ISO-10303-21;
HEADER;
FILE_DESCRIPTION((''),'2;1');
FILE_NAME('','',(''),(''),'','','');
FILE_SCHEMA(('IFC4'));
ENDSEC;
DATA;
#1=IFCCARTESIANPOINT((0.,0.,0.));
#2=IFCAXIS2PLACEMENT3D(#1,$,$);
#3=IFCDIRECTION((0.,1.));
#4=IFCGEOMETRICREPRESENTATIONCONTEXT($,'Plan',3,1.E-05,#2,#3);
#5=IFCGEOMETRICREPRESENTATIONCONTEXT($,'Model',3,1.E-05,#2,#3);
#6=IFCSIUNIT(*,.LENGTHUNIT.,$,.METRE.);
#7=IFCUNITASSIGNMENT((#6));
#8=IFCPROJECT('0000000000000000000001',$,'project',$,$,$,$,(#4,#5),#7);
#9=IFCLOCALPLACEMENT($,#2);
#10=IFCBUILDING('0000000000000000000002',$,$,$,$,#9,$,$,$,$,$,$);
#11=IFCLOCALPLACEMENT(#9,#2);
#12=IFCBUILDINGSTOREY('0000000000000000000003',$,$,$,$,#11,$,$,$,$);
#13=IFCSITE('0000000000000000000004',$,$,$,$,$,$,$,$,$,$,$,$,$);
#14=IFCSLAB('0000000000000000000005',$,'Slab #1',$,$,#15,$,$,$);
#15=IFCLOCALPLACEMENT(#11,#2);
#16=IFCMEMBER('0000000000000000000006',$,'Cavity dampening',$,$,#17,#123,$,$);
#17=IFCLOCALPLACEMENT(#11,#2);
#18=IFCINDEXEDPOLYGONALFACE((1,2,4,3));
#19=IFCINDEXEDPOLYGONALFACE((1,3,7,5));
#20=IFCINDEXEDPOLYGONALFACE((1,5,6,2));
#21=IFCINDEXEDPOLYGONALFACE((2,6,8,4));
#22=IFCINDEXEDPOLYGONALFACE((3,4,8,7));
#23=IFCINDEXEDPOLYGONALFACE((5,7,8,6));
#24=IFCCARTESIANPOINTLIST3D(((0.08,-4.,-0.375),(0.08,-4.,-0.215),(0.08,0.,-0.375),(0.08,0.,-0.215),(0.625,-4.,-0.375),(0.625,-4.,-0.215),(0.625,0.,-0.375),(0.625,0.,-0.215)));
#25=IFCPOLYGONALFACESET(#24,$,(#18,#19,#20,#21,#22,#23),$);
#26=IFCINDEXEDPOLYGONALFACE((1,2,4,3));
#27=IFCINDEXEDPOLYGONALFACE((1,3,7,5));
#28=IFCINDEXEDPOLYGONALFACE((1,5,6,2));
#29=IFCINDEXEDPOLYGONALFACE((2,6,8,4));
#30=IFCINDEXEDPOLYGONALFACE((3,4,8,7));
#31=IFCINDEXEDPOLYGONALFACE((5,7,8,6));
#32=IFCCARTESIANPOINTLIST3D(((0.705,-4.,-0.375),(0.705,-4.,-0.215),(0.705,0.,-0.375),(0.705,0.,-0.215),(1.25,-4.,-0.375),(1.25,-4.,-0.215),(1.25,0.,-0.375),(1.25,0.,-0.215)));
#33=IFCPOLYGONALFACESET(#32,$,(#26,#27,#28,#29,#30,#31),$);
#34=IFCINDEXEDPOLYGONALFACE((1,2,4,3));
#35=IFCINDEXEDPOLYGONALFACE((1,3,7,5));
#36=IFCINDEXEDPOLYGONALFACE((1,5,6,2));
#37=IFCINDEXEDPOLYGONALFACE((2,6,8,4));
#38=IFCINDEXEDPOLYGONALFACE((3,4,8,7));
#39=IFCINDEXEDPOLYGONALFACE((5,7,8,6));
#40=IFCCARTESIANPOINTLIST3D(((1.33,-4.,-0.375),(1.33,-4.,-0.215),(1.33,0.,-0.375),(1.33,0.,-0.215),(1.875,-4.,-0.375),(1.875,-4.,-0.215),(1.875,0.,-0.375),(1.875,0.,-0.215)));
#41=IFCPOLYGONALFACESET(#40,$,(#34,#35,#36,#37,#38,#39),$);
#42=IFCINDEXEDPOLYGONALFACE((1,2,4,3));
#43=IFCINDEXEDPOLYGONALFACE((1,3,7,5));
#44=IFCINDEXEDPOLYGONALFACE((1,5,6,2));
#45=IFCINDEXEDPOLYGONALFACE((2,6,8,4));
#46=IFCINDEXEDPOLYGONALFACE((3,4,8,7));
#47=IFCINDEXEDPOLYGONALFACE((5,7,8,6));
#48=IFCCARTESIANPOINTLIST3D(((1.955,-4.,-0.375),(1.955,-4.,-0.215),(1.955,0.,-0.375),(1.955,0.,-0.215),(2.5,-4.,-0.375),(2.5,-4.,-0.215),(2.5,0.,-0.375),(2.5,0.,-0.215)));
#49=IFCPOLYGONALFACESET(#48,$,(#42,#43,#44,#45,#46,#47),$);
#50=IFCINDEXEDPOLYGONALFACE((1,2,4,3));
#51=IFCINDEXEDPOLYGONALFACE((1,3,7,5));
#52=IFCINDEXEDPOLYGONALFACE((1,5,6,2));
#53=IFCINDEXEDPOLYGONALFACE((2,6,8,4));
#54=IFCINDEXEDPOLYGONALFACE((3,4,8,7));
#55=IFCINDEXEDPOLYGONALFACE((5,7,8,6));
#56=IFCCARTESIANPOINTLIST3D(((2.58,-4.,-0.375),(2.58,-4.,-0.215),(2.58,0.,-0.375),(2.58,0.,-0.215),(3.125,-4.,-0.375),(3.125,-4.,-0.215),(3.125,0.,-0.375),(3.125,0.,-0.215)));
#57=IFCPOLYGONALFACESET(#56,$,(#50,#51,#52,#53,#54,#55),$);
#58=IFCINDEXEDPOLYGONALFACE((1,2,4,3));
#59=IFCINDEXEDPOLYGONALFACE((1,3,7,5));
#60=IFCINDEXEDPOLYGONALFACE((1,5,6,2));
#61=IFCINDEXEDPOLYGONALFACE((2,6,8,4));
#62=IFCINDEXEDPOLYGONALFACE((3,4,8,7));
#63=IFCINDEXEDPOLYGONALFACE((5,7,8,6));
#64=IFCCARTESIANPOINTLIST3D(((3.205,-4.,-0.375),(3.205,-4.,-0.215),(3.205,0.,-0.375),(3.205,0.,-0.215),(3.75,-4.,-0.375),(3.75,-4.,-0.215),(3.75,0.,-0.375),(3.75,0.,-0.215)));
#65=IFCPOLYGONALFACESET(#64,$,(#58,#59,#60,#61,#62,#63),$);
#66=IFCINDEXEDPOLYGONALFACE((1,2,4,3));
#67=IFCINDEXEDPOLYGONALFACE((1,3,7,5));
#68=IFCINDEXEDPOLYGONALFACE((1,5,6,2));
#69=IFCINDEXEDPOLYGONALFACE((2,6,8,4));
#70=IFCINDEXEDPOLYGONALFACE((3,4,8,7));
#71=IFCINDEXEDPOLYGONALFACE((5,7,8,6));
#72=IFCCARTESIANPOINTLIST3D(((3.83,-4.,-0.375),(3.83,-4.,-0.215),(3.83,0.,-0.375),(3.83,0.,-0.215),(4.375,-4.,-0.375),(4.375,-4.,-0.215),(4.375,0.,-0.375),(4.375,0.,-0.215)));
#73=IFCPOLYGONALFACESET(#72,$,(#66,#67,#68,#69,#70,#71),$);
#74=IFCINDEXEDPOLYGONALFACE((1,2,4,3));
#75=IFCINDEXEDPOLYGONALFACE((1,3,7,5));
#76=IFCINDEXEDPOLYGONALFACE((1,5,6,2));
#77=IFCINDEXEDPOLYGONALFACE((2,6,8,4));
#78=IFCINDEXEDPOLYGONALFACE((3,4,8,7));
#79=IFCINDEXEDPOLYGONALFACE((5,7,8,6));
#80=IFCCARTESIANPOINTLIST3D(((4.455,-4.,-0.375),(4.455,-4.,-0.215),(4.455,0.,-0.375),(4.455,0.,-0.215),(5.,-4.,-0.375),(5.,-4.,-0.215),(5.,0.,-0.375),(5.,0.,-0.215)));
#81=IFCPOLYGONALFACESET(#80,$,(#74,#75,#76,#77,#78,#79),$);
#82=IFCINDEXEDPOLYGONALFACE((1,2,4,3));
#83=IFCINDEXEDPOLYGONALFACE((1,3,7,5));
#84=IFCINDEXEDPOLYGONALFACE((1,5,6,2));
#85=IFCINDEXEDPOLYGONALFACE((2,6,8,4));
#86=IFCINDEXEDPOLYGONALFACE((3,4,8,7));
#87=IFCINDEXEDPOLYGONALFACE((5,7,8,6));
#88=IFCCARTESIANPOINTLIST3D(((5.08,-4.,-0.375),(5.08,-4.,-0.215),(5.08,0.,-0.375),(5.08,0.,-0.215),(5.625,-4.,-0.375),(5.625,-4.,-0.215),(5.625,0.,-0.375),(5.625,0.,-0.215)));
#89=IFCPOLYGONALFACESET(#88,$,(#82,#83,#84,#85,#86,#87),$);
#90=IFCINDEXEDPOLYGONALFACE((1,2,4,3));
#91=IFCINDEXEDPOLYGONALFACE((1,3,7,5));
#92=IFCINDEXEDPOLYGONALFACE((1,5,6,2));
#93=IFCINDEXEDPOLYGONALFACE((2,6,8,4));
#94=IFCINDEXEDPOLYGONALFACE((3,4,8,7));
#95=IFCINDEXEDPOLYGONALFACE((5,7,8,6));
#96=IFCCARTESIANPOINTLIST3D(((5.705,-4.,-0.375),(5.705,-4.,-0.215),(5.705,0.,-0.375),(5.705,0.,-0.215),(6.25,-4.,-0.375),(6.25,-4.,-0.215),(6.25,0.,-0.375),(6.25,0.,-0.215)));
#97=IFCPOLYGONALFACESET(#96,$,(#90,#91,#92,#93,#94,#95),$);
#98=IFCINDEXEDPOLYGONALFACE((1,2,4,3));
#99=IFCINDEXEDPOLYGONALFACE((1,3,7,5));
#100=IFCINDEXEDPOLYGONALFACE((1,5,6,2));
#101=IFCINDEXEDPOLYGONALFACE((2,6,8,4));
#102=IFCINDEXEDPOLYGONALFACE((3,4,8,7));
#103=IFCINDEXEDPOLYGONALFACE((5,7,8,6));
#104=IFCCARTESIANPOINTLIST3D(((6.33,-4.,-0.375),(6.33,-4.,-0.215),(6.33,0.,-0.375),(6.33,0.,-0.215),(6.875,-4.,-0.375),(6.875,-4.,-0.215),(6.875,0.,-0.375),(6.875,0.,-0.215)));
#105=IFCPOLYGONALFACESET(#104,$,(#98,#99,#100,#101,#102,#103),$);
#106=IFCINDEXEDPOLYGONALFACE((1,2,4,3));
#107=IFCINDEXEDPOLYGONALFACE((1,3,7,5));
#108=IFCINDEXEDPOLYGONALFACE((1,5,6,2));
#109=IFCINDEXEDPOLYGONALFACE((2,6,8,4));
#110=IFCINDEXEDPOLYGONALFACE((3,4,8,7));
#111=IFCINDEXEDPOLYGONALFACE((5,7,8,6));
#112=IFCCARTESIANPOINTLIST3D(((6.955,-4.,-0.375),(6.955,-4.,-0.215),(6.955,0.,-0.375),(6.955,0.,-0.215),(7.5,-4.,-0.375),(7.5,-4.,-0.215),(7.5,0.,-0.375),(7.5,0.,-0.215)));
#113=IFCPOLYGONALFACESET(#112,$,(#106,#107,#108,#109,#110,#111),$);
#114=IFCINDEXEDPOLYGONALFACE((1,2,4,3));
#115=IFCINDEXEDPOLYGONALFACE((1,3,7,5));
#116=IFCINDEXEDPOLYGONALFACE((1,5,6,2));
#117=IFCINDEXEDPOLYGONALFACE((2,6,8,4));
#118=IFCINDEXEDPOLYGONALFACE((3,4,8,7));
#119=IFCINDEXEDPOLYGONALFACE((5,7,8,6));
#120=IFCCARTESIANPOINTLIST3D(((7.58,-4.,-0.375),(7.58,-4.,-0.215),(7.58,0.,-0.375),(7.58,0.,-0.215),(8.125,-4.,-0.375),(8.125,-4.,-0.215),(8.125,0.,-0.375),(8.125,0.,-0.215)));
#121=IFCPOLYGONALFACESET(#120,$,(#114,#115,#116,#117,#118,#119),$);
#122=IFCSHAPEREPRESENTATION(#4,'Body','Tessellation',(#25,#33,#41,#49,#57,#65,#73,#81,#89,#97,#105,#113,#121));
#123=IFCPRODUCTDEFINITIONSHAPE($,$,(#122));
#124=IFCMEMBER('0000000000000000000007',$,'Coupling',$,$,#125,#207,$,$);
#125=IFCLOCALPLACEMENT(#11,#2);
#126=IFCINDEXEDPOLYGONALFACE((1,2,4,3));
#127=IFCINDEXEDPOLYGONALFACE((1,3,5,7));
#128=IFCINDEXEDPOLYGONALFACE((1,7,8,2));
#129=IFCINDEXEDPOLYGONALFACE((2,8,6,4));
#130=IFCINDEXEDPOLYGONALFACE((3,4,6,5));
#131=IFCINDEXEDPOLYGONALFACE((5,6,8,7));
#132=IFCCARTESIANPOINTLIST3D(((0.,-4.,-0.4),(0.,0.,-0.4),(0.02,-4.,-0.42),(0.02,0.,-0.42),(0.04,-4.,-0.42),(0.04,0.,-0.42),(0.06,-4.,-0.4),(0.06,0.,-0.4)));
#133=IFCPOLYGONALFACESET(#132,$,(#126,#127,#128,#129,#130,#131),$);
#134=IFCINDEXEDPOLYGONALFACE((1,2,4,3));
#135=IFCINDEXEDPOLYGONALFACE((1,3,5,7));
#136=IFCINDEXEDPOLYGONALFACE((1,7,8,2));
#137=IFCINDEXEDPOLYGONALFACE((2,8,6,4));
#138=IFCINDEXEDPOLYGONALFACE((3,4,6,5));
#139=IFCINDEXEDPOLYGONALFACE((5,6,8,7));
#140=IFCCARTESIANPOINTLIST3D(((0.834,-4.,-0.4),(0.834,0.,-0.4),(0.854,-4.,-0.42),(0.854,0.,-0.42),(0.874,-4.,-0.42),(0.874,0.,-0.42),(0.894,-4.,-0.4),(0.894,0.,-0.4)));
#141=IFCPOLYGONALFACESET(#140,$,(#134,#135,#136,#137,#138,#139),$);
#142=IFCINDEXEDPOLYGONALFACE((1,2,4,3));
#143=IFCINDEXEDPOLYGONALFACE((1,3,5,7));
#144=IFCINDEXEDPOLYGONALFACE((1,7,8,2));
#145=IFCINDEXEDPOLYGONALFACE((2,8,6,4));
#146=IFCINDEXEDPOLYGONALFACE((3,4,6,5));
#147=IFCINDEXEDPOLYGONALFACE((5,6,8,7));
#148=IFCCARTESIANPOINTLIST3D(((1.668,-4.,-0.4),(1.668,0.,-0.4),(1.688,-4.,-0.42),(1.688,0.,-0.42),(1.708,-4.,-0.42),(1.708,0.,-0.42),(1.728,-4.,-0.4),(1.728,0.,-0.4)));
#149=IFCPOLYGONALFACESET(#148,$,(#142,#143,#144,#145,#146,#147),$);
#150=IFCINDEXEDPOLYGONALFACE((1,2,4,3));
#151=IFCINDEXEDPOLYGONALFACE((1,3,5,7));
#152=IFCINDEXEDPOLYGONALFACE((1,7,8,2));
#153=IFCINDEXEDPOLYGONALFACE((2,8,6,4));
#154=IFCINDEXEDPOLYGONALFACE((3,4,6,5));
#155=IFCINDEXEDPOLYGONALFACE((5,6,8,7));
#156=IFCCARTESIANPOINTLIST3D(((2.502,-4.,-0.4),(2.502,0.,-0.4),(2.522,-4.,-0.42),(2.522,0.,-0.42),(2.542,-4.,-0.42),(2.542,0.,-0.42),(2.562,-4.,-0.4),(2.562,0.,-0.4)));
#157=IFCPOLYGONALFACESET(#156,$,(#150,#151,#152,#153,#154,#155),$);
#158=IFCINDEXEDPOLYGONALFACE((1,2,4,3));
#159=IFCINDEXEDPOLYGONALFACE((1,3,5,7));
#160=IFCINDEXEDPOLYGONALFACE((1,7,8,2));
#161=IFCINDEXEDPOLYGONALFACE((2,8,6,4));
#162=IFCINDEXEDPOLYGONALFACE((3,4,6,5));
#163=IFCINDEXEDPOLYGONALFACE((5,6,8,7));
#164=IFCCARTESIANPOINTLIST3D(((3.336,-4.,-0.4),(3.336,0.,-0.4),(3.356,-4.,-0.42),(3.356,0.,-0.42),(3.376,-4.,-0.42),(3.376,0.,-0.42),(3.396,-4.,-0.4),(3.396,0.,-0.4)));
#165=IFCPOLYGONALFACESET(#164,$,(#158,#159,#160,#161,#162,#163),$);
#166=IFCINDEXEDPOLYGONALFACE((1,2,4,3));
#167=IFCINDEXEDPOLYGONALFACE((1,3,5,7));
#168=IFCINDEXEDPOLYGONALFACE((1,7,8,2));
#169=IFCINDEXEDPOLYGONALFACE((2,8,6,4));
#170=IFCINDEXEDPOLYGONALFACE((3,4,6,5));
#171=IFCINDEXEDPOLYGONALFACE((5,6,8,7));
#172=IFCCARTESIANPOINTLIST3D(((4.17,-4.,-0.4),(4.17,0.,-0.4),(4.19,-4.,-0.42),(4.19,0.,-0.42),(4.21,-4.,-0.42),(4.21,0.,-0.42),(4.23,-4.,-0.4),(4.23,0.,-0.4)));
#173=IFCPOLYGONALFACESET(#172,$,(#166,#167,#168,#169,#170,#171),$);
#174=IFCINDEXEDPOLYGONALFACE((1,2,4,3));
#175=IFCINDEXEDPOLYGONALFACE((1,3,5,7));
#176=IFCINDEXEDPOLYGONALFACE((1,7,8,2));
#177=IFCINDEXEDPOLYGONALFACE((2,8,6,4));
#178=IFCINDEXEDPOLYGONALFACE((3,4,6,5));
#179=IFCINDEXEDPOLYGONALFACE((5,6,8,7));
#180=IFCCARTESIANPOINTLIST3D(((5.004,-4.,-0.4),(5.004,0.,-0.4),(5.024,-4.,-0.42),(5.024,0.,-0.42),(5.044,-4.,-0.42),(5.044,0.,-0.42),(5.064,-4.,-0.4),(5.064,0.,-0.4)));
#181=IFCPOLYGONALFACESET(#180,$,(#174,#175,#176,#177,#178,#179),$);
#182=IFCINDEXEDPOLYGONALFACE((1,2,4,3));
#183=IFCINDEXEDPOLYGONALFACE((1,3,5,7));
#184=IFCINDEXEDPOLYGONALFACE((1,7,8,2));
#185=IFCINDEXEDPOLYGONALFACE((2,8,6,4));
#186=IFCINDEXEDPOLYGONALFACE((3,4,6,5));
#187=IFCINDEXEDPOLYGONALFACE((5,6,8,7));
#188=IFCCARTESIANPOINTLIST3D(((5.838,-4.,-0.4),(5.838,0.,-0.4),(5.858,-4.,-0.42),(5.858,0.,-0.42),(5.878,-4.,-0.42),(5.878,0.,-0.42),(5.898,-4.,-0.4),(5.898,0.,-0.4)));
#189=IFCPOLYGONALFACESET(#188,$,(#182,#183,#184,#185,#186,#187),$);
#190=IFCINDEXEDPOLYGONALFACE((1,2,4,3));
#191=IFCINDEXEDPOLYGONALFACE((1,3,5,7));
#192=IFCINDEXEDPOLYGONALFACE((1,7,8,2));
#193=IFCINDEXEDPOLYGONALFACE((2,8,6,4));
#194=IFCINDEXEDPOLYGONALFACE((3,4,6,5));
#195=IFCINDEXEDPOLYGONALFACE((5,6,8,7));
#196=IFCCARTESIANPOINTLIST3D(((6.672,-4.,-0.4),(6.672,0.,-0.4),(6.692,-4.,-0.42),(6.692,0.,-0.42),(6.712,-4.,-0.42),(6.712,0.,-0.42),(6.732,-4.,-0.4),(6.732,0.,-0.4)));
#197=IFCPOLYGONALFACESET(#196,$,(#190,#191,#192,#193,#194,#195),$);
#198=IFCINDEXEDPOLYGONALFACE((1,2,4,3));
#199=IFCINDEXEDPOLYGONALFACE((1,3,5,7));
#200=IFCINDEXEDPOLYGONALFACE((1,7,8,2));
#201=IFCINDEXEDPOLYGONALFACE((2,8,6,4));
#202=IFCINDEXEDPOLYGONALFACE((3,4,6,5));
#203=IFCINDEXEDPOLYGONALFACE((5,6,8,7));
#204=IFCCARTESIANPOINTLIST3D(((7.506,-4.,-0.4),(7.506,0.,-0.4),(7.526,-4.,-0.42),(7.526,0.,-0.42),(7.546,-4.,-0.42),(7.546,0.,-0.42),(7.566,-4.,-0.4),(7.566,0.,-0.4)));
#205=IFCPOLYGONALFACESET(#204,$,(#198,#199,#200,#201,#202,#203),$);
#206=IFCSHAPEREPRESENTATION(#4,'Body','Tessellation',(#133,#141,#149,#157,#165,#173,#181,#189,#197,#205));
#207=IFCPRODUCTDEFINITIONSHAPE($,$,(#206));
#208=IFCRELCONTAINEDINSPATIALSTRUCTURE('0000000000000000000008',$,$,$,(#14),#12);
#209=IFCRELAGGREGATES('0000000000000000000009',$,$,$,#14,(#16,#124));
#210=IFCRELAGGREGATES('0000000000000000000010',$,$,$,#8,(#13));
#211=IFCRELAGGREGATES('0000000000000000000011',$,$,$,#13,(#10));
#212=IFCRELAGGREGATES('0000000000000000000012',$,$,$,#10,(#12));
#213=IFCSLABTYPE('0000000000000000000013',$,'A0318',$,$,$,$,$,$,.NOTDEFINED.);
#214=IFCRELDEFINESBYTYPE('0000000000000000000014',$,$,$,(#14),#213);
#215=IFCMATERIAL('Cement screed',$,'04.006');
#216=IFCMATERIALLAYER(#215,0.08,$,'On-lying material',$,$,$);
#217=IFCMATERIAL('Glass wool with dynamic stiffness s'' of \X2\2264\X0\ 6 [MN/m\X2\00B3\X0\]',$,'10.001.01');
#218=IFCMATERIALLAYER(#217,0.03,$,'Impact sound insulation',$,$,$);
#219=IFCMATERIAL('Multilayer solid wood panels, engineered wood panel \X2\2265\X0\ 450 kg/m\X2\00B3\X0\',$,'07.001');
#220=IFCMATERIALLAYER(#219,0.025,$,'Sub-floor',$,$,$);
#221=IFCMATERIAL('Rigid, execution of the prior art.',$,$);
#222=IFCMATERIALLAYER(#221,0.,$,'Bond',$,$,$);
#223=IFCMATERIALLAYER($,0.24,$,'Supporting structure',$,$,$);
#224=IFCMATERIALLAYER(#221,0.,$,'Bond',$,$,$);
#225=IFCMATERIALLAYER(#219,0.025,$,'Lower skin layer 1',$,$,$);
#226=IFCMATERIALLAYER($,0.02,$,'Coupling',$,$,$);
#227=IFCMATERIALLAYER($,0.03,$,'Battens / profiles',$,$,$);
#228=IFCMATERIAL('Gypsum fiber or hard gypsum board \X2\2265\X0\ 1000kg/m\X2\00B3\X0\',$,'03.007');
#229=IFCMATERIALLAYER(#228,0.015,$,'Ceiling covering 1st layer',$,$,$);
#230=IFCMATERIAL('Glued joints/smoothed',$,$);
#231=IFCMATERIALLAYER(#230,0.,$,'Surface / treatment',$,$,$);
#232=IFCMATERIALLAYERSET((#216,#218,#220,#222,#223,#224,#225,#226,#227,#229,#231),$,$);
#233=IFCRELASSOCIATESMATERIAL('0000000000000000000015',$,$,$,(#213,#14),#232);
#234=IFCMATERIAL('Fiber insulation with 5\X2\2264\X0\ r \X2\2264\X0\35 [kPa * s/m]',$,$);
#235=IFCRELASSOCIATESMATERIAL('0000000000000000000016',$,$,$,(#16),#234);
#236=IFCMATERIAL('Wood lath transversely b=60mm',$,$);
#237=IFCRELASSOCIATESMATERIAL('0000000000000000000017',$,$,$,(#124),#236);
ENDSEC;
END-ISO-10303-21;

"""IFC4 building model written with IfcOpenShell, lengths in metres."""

from ifc_helpers import new_model, si_unit, direction, frame, frame_2d, origin, place, context, project, spatial, polyline, rectangle, outline, extrude, material, layer, layer_set, type_object, element, aggregate, save


model = new_model("IFC4")

# Units and contexts
plan_context = context("Plan", 3, precision=1e-05, world=origin(), true_north=direction((0.0, 1.0)))
model_context = context("Model", 3, precision=1e-05, world=origin(), true_north=direction((0.0, 1.0)))
ifc_project = project(units=[si_unit("LENGTHUNIT", "METRE")], contexts=[plan_context, model_context])

# Site, building, storey
site = spatial("IfcSite", under=ifc_project)
building_placement = place(None, origin())
building = spatial("IfcBuilding", under=site, at=building_placement)
storey_placement = place(building_placement, origin())
storey = spatial("IfcBuildingStorey", under=building, at=storey_placement)

# Slab, members
ifc_material_1 = material(Name="Cement screed", Category="04.006")
ifc_layer_1 = layer(ifc_material_1, 0.08, Name="On-lying material")
ifc_material_2 = material(Name="Glass wool with dynamic stiffness s' of ≤ 6 [MN/m³]", Category="10.001.01")
ifc_layer_2 = layer(ifc_material_2, 0.03, Name="Impact sound insulation")
ifc_material_3 = material(Name="Multilayer solid wood panels, engineered wood panel ≥ 450 kg/m³", Category="07.001")
ifc_layer_3 = layer(ifc_material_3, 0.025, Name="Sub-floor")
ifc_material_4 = material(Name="Rigid, execution of the prior art.")
ifc_layer_4 = layer(ifc_material_4, 0.0, Name="Bond")
ifc_layer_5 = layer(None, 0.24, Name="Supporting structure")
ifc_layer_6 = layer(ifc_material_4, 0.0, Name="Bond")
ifc_layer_7 = layer(ifc_material_3, 0.025, Name="Lower skin layer 1")
ifc_layer_8 = layer(None, 0.02, Name="Coupling")
ifc_layer_9 = layer(None, 0.03, Name="Battens / profiles")
ifc_material_5 = material(Name="Gypsum fiber or hard gypsum board ≥ 1000kg/m³", Category="03.007")
ifc_layer_10 = layer(ifc_material_5, 0.015, Name="Ceiling covering 1st layer")
ifc_material_6 = material(Name="Glued joints/smoothed")
ifc_layer_11 = layer(ifc_material_6, 0.0, Name="Surface / treatment")
ifc_layer_set = layer_set([ifc_layer_1, ifc_layer_2, ifc_layer_3, ifc_layer_4, ifc_layer_5, ifc_layer_6, ifc_layer_7, ifc_layer_8, ifc_layer_9, ifc_layer_10, ifc_layer_11])
slab_type = type_object("IfcSlabType", Name="A0318", PredefinedType="NOTDEFINED", material=ifc_layer_set)
slab_placement = place(None, frame((0.0, 0.0, 0.0), z_axis=(0.0, 0.0, -1.0), x_axis=(1.0, 0.0, 0.0)))
slab = element("IfcSlab", 1, at=slab_placement, inside=storey, type_object=slab_type, material=ifc_layer_set, Name="Slab #1")
ifc_material_7 = material(Name="Fiber insulation with 5≤ r ≤35 [kPa * s/m]")
member_1_placement = place(slab_placement, origin())
member_1 = element("IfcMember", 2, at=member_1_placement, material=ifc_material_7, Name="Cavity dampening", context=plan_context, shape_type="SweptSolid", body=[
    extrude(rectangle(XDim=0.545, YDim=0.16, at=frame_2d((0.2725, 0.08), x_axis=(1.0, 0.0))), frame((0.08, 4.0, 0.215), z_axis=(0.0, -1.0, 0.0), x_axis=(1.0, 0.0, 0.0)), (0.0, 0.0, 1.0), 4.0),
    extrude(rectangle(XDim=0.545, YDim=0.16, at=frame_2d((0.2725, 0.08), x_axis=(1.0, 0.0))), frame((0.705, 4.0, 0.215), z_axis=(0.0, -1.0, 0.0), x_axis=(1.0, 0.0, 0.0)), (0.0, 0.0, 1.0), 4.0),
    extrude(rectangle(XDim=0.545, YDim=0.16, at=frame_2d((0.2725, 0.08), x_axis=(1.0, 0.0))), frame((1.33, 4.0, 0.215), z_axis=(0.0, -1.0, 0.0), x_axis=(1.0, 0.0, 0.0)), (0.0, 0.0, 1.0), 4.0),
    extrude(rectangle(XDim=0.545, YDim=0.16, at=frame_2d((0.2725, 0.08), x_axis=(1.0, 0.0))), frame((1.955, 4.0, 0.215), z_axis=(0.0, -1.0, 0.0), x_axis=(1.0, 0.0, 0.0)), (0.0, 0.0, 1.0), 4.0),
    extrude(rectangle(XDim=0.545, YDim=0.16, at=frame_2d((0.2725, 0.08), x_axis=(1.0, 0.0))), frame((2.58, 4.0, 0.215), z_axis=(0.0, -1.0, 0.0), x_axis=(1.0, 0.0, 0.0)), (0.0, 0.0, 1.0), 4.0),
    extrude(rectangle(XDim=0.545, YDim=0.16, at=frame_2d((0.2725, 0.08), x_axis=(1.0, 0.0))), frame((3.205, 4.0, 0.215), z_axis=(0.0, -1.0, 0.0), x_axis=(1.0, 0.0, 0.0)), (0.0, 0.0, 1.0), 4.0),
    extrude(rectangle(XDim=0.545, YDim=0.16, at=frame_2d((0.2725, 0.08), x_axis=(1.0, 0.0))), frame((3.83, 4.0, 0.215), z_axis=(0.0, -1.0, 0.0), x_axis=(1.0, 0.0, 0.0)), (0.0, 0.0, 1.0), 4.0),
    extrude(rectangle(XDim=0.545, YDim=0.16, at=frame_2d((0.2725, 0.08), x_axis=(1.0, 0.0))), frame((4.455, 4.0, 0.215), z_axis=(0.0, -1.0, 0.0), x_axis=(1.0, 0.0, 0.0)), (0.0, 0.0, 1.0), 4.0),
    extrude(rectangle(XDim=0.545, YDim=0.16, at=frame_2d((0.2725, 0.08), x_axis=(1.0, 0.0))), frame((5.08, 4.0, 0.215), z_axis=(0.0, -1.0, 0.0), x_axis=(1.0, 0.0, 0.0)), (0.0, 0.0, 1.0), 4.0),
    extrude(rectangle(XDim=0.545, YDim=0.16, at=frame_2d((0.2725, 0.08), x_axis=(1.0, 0.0))), frame((5.705, 4.0, 0.215), z_axis=(0.0, -1.0, 0.0), x_axis=(1.0, 0.0, 0.0)), (0.0, 0.0, 1.0), 4.0),
    extrude(rectangle(XDim=0.545, YDim=0.16, at=frame_2d((0.2725, 0.08), x_axis=(1.0, 0.0))), frame((6.33, 4.0, 0.215), z_axis=(0.0, -1.0, 0.0), x_axis=(1.0, 0.0, 0.0)), (0.0, 0.0, 1.0), 4.0),
    extrude(rectangle(XDim=0.545, YDim=0.16, at=frame_2d((0.2725, 0.08), x_axis=(1.0, 0.0))), frame((6.955, 4.0, 0.215), z_axis=(0.0, -1.0, 0.0), x_axis=(1.0, 0.0, 0.0)), (0.0, 0.0, 1.0), 4.0),
    extrude(rectangle(XDim=0.545, YDim=0.16, at=frame_2d((0.2725, 0.08), x_axis=(1.0, 0.0))), frame((7.58, 4.0, 0.215), z_axis=(0.0, -1.0, 0.0), x_axis=(1.0, 0.0, 0.0)), (0.0, 0.0, 1.0), 4.0),
])
ifc_material_8 = material(Name="Wood lath transversely b=60mm")
member_2_placement = place(slab_placement, origin())
member_2 = element("IfcMember", 3, at=member_2_placement, material=ifc_material_8, Name="Coupling", context=plan_context, shape_type="SweptSolid", body=[
    extrude(outline(polyline([(0.0, 0.0), (0.06, 0.0), (0.04, 0.02), (0.02, 0.02), (0.0, 0.0)])), frame((0.0, 4.0, 0.4), z_axis=(0.0, -1.0, 0.0), x_axis=(1.0, 0.0, 0.0)), (0.0, 0.0, 1.0), 4.0),
    extrude(outline(polyline([(0.0, 0.0), (0.06, 0.0), (0.04, 0.02), (0.02, 0.02), (0.0, 0.0)])), frame((0.834, 4.0, 0.4), z_axis=(0.0, -1.0, 0.0), x_axis=(1.0, 0.0, 0.0)), (0.0, 0.0, 1.0), 4.0),
    extrude(outline(polyline([(0.0, 0.0), (0.06, 0.0), (0.04, 0.02), (0.02, 0.02), (0.0, 0.0)])), frame((1.668, 4.0, 0.4), z_axis=(0.0, -1.0, 0.0), x_axis=(1.0, 0.0, 0.0)), (0.0, 0.0, 1.0), 4.0),
    extrude(outline(polyline([(0.0, 0.0), (0.06, 0.0), (0.04, 0.02), (0.02, 0.02), (0.0, 0.0)])), frame((2.502, 4.0, 0.4), z_axis=(0.0, -1.0, 0.0), x_axis=(1.0, 0.0, 0.0)), (0.0, 0.0, 1.0), 4.0),
    extrude(outline(polyline([(0.0, 0.0), (0.06, 0.0), (0.04, 0.02), (0.02, 0.02), (0.0, 0.0)])), frame((3.336, 4.0, 0.4), z_axis=(0.0, -1.0, 0.0), x_axis=(1.0, 0.0, 0.0)), (0.0, 0.0, 1.0), 4.0),
    extrude(outline(polyline([(0.0, 0.0), (0.06, 0.0), (0.04, 0.02), (0.02, 0.02), (0.0, 0.0)])), frame((4.17, 4.0, 0.4), z_axis=(0.0, -1.0, 0.0), x_axis=(1.0, 0.0, 0.0)), (0.0, 0.0, 1.0), 4.0),
    extrude(outline(polyline([(0.0, 0.0), (0.06, 0.0), (0.04, 0.02), (0.02, 0.02), (0.0, 0.0)])), frame((5.004, 4.0, 0.4), z_axis=(0.0, -1.0, 0.0), x_axis=(1.0, 0.0, 0.0)), (0.0, 0.0, 1.0), 4.0),
    extrude(outline(polyline([(0.0, 0.0), (0.06, 0.0), (0.04, 0.02), (0.02, 0.02), (0.0, 0.0)])), frame((5.838, 4.0, 0.4), z_axis=(0.0, -1.0, 0.0), x_axis=(1.0, 0.0, 0.0)), (0.0, 0.0, 1.0), 4.0),
    extrude(outline(polyline([(0.0, 0.0), (0.06, 0.0), (0.04, 0.02), (0.02, 0.02), (0.0, 0.0)])), frame((6.672, 4.0, 0.4), z_axis=(0.0, -1.0, 0.0), x_axis=(1.0, 0.0, 0.0)), (0.0, 0.0, 1.0), 4.0),
    extrude(outline(polyline([(0.0, 0.0), (0.06, 0.0), (0.04, 0.02), (0.02, 0.02), (0.0, 0.0)])), frame((7.506, 4.0, 0.4), z_axis=(0.0, -1.0, 0.0), x_axis=(1.0, 0.0, 0.0)), (0.0, 0.0, 1.0), 4.0),
])
aggregate(slab, [member_1, member_2])

save(model, "model.ifc")
